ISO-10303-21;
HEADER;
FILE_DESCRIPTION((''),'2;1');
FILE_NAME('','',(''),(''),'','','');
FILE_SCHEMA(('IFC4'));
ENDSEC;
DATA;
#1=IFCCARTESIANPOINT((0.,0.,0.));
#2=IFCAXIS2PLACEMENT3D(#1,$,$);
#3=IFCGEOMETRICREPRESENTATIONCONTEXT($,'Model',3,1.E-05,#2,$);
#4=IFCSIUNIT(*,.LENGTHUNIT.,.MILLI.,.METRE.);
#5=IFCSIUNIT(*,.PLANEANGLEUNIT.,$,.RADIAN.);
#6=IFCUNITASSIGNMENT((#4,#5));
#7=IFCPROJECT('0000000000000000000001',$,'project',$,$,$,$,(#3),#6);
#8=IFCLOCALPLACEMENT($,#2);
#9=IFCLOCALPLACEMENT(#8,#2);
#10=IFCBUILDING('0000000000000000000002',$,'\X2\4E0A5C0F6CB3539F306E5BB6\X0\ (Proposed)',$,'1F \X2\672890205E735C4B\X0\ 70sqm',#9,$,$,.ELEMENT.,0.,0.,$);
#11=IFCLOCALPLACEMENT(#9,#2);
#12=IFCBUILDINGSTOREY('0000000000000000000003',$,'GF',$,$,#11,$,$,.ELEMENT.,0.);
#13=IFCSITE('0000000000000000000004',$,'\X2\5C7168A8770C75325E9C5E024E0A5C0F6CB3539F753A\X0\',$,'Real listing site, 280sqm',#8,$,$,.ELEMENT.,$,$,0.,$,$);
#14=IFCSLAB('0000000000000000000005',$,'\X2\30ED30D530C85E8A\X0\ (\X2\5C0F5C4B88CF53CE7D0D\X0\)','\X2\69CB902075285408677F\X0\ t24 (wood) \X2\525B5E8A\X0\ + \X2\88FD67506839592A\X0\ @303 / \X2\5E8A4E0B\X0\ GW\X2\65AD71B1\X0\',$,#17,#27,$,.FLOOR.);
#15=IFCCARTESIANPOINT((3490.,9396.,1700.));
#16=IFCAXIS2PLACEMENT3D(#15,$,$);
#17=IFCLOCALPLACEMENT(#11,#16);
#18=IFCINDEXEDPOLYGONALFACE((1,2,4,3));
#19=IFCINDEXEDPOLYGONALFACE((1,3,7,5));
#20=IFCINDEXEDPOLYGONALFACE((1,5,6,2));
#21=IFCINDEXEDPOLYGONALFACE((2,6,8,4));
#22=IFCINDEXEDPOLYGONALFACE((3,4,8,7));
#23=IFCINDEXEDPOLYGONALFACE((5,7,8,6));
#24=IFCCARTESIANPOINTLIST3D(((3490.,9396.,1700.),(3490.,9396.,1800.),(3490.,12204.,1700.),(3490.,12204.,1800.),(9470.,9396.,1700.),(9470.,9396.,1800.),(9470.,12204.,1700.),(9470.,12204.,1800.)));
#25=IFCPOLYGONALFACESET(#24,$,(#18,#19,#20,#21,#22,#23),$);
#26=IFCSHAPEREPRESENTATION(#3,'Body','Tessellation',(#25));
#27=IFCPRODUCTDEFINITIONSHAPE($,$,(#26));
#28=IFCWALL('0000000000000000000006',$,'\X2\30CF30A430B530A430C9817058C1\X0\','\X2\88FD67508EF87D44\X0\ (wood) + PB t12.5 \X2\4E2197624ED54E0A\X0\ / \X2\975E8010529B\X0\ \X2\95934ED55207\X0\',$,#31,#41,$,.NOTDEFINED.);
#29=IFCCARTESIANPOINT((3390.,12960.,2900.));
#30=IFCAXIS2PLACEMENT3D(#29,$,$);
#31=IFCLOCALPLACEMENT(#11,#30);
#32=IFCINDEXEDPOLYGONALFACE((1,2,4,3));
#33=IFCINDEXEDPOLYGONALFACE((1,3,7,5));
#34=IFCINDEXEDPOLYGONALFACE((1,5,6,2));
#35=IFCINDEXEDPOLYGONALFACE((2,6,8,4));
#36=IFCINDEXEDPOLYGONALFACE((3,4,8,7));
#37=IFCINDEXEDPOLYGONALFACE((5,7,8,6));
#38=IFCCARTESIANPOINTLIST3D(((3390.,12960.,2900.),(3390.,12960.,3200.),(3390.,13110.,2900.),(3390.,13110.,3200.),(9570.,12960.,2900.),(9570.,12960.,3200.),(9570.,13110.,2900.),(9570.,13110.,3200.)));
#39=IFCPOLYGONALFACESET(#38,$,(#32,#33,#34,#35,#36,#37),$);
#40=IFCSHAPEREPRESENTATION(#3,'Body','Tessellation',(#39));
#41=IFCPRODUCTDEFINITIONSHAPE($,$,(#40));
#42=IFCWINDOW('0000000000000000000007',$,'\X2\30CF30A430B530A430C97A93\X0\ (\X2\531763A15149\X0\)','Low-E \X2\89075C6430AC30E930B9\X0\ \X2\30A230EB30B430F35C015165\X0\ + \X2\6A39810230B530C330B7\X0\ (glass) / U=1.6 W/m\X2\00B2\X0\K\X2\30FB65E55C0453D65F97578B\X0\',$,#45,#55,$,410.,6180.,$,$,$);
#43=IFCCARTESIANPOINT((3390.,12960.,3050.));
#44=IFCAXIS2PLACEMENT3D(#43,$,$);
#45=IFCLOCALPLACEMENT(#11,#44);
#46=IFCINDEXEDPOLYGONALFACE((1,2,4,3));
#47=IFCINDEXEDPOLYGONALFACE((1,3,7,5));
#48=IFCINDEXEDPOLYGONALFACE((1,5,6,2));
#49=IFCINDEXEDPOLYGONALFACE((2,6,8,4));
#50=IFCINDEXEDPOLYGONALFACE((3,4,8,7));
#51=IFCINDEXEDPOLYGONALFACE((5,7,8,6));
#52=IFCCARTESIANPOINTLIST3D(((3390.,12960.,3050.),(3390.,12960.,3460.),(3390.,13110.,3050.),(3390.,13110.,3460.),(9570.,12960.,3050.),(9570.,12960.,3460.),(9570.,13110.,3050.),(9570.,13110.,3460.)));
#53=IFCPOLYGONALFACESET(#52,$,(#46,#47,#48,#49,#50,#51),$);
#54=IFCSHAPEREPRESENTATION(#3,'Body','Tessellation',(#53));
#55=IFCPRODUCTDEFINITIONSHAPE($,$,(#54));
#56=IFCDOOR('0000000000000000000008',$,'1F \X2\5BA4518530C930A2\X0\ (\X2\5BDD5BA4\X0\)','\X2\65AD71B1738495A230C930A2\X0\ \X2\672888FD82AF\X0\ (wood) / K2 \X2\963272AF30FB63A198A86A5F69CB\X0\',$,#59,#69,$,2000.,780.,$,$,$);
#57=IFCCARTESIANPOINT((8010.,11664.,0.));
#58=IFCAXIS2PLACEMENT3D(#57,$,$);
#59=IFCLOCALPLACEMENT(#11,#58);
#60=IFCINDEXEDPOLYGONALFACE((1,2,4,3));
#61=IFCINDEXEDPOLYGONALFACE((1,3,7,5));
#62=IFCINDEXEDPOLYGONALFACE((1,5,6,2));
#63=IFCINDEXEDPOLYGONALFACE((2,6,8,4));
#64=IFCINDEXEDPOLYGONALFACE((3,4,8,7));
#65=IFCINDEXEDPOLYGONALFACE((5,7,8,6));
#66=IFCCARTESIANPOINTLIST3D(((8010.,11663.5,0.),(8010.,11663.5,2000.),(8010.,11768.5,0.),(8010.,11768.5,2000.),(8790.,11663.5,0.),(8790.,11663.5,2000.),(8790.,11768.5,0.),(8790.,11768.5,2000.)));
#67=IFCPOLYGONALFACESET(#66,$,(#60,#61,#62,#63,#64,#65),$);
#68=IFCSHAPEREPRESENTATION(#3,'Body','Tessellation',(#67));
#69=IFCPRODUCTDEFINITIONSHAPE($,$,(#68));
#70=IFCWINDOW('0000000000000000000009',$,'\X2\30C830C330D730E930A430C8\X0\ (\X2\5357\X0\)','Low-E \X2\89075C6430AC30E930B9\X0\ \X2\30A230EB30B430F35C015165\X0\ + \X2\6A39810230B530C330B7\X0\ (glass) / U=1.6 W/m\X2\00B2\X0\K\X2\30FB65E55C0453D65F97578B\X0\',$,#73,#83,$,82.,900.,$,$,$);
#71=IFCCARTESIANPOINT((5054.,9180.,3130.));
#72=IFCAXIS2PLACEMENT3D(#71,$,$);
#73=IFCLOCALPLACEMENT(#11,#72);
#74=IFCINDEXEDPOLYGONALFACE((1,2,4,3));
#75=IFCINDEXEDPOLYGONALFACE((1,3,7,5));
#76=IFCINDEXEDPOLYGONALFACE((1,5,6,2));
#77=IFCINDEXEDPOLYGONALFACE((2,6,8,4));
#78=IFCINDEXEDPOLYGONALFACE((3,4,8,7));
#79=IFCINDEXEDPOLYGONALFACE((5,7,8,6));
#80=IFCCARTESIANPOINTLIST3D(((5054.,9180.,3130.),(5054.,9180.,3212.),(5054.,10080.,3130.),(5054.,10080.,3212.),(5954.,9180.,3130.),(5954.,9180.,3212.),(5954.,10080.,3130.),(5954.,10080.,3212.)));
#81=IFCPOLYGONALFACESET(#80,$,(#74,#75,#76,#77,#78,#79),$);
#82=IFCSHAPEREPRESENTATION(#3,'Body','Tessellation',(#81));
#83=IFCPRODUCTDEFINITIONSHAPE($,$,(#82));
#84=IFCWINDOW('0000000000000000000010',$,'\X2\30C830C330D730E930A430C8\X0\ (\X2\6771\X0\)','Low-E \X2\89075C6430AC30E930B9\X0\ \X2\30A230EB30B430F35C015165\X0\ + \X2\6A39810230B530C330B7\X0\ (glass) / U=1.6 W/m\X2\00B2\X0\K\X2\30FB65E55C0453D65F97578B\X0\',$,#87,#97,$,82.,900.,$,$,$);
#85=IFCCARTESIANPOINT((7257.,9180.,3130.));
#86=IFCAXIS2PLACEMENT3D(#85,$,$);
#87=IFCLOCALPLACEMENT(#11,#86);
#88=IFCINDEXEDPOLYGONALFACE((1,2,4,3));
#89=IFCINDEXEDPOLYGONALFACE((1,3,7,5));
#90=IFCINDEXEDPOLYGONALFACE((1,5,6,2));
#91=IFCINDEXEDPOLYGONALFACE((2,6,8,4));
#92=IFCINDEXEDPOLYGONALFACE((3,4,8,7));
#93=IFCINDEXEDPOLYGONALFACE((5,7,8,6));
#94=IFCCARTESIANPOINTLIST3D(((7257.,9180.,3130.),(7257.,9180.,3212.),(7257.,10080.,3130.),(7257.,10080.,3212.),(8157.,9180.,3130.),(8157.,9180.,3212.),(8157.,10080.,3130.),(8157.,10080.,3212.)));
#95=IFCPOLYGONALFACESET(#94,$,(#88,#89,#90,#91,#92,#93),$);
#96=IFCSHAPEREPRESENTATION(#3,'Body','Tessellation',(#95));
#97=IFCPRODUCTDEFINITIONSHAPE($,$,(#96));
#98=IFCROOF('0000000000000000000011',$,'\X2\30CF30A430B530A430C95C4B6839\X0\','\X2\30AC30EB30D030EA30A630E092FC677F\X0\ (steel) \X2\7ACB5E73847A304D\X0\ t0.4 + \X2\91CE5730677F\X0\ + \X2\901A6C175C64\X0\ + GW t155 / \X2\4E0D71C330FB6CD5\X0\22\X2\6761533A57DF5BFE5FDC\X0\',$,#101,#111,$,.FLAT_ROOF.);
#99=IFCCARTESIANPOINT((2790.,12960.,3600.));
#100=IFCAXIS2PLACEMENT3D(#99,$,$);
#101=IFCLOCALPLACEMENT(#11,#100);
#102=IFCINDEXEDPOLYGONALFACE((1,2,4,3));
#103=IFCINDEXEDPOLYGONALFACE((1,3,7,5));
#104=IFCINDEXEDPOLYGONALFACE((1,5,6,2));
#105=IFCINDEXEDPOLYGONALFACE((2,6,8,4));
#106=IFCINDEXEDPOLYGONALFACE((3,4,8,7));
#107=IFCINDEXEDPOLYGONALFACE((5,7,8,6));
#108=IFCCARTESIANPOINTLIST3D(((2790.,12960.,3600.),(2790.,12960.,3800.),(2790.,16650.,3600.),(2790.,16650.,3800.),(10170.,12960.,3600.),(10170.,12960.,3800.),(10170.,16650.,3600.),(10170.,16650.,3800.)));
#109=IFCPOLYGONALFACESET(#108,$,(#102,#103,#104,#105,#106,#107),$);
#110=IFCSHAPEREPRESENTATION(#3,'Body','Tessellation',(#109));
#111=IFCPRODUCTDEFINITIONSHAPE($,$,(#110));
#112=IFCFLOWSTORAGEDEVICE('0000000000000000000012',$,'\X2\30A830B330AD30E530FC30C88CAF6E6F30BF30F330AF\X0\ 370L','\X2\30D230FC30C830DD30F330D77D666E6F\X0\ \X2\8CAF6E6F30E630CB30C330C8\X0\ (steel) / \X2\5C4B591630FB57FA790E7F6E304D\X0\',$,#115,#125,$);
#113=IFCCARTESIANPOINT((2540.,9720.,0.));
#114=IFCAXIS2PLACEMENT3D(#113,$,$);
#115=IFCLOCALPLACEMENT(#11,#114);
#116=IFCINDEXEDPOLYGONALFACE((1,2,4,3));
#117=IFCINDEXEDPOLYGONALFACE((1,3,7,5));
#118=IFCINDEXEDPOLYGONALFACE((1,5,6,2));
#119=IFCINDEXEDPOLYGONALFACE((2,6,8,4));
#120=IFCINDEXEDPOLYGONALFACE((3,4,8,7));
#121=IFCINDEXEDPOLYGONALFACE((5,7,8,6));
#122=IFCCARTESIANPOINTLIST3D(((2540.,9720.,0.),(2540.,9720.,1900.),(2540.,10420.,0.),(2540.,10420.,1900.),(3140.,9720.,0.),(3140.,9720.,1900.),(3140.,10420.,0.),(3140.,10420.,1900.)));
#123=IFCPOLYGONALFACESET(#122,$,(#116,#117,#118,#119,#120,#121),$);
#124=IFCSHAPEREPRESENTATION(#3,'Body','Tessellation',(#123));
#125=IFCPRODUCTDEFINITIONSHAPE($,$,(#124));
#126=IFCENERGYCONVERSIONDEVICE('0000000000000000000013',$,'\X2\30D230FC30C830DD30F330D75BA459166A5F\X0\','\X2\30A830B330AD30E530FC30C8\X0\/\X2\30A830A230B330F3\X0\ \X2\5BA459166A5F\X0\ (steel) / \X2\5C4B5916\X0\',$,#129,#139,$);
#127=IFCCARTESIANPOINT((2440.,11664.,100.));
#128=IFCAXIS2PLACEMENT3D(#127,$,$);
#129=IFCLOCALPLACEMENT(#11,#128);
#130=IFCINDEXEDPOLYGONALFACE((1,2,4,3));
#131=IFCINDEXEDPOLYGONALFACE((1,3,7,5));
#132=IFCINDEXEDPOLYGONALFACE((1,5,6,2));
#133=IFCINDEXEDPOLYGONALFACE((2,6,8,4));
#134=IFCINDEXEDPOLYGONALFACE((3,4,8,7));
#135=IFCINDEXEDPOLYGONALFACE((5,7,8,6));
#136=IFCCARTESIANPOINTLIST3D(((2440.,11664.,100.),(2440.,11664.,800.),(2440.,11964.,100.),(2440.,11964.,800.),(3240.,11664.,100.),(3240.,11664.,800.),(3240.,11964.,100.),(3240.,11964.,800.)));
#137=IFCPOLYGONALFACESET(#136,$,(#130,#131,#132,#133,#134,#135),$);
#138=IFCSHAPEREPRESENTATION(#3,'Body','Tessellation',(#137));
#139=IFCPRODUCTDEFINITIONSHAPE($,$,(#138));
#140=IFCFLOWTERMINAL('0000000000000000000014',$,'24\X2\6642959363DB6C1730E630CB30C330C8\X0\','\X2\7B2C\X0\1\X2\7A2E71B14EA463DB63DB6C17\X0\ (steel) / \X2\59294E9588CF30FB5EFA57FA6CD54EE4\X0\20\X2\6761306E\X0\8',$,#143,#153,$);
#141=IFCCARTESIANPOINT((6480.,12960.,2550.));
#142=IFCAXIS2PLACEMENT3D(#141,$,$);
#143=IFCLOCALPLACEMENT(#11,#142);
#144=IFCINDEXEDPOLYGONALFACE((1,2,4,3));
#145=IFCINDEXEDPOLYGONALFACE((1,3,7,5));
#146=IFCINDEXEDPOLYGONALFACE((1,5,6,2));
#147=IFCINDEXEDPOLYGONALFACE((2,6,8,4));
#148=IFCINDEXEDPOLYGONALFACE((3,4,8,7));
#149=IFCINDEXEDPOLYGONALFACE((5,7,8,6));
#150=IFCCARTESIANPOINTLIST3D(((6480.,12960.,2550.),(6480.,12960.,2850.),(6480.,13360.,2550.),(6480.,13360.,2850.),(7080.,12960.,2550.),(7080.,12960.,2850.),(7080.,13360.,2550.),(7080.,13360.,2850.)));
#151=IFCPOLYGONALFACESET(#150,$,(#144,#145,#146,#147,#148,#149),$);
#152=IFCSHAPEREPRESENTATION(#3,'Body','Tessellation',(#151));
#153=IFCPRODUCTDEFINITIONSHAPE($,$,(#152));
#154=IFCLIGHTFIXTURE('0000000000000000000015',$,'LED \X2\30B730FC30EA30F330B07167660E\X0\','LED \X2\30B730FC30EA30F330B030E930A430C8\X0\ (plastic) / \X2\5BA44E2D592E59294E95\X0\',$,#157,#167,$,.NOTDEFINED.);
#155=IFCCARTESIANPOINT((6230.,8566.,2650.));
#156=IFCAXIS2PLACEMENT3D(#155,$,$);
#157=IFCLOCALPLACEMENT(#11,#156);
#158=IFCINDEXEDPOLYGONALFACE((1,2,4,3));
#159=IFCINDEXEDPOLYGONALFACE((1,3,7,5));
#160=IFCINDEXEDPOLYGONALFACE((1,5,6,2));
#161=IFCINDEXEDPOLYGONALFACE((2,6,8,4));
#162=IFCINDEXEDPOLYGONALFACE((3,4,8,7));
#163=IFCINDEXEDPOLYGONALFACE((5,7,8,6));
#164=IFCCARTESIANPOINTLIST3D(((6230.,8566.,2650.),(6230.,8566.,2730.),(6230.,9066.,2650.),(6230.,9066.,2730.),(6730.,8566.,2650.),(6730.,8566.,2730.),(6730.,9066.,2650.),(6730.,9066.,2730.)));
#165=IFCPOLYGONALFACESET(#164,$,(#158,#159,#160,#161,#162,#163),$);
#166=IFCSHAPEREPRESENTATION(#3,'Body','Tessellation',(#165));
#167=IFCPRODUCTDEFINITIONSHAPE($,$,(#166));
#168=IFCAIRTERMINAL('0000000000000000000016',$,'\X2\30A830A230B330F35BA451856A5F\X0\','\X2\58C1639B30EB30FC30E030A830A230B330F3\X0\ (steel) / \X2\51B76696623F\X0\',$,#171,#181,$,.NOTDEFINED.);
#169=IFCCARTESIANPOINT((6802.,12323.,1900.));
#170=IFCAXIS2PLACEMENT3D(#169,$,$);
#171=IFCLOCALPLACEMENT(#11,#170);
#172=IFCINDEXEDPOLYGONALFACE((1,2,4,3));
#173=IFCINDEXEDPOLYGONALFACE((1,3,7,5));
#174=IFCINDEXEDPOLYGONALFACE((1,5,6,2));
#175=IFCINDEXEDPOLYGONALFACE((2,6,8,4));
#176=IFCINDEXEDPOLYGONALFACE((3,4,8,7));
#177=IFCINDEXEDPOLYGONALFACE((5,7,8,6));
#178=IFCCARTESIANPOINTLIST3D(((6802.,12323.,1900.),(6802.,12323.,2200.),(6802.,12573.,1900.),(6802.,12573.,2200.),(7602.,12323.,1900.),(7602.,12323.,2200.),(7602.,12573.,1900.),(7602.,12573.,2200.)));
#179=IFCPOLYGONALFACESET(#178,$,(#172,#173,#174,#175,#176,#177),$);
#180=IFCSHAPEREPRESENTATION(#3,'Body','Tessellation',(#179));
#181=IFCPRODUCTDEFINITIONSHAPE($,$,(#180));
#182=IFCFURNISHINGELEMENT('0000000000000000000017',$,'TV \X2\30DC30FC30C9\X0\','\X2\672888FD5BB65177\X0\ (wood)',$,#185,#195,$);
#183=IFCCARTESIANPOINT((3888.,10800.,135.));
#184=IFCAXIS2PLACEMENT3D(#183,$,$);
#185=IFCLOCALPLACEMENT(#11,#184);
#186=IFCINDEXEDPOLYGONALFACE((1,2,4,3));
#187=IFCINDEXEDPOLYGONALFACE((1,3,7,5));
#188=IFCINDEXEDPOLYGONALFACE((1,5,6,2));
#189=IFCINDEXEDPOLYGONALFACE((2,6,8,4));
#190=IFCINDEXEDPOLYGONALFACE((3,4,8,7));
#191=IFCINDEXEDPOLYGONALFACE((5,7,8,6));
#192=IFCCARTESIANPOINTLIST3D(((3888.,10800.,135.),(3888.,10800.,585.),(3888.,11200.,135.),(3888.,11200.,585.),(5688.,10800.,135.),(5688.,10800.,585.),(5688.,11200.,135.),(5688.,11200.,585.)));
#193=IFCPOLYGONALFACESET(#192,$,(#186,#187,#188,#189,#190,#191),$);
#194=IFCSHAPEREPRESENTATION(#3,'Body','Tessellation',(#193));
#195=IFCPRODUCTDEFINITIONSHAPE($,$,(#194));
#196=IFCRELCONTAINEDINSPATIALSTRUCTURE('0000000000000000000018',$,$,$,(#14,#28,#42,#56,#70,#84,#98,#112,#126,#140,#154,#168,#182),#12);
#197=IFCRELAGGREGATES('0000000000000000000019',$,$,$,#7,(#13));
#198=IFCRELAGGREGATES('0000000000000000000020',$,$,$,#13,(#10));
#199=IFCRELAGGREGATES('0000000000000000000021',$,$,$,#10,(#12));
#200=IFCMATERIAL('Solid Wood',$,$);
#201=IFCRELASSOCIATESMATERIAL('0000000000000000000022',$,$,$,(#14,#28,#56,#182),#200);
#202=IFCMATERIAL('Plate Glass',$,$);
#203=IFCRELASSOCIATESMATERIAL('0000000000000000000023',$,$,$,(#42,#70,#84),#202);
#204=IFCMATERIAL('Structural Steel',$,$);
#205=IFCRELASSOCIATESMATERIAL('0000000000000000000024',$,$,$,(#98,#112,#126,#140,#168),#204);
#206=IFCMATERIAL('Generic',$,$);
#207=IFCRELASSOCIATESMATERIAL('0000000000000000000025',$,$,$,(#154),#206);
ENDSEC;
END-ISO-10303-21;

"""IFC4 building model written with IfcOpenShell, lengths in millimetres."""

from ifc_helpers import new_model, si_unit, frame, frame_2d, origin, place, context, project, spatial, rectangle, extrude, material, element, fill, save


model = new_model("IFC4")

# Units and contexts
model_context = context("Model", 3, precision=1e-05, world=origin())
ifc_project = project(units=[si_unit("LENGTHUNIT", "METRE", prefix="MILLI"), si_unit("PLANEANGLEUNIT", "RADIAN")], contexts=[model_context])

# Site, building, storey
site_placement = place(None, origin())
site = spatial("IfcSite", under=ifc_project, at=site_placement, Name="山梨県甲府市上小河原町", ObjectType="Real listing site, 280sqm", CompositionType="ELEMENT", RefElevation=0.0)
building_placement = place(site_placement, origin())
building = spatial("IfcBuilding", under=site, at=building_placement, Name="上小河原の家 (Proposed)", ObjectType="1F 木造平屋 70sqm", CompositionType="ELEMENT", ElevationOfRefHeight=0.0, ElevationOfTerrain=0.0)
storey_placement = place(building_placement, origin())
storey = spatial("IfcBuildingStorey", under=building, at=storey_placement, Name="GF", CompositionType="ELEMENT", Elevation=0.0)

# Shared definitions
ifc_material_1 = material(Name="Solid Wood")

# Slab
slab_placement = place(storey_placement, frame((3490.0, 9396.0, 1700.0)))
element("IfcSlab", 1, at=slab_placement, inside=storey, material=ifc_material_1, Name="ロフト床 (小屋裏収納)", Description="構造用合板 t24 (wood) 剛床 + 製材根太 @303 / 床下 GW断熱", PredefinedType="FLOOR", context=model_context, shape_type="SweptSolid", body=[
    extrude(rectangle(XDim=5980.0, YDim=2808.0, at=frame_2d((2990.0, 1404.0))), frame((3490.0, 9396.0, 1700.0)), (0.0, 0.0, 1.0), 100.0),
])

# Wall, opening, window
wall_1_placement = place(storey_placement, frame((3390.0, 12960.0, 2900.0)))
wall_1 = element("IfcWall", 2, at=wall_1_placement, inside=storey, material=ifc_material_1, Name="ハイサイド腰壁", Description="製材軸組 (wood) + PB t12.5 両面仕上 / 非耐力 間仕切", PredefinedType="NOTDEFINED", context=model_context, shape_type="SweptSolid", body=[
    extrude(rectangle(XDim=6180.0, YDim=150.0, at=frame_2d((3090.0, 75.0))), frame((3390.0, 12960.0, 2900.0)), (0.0, 0.0, 1.0), 700.0),
])
opening_1_placement = place(storey_placement, frame((3390.0, 12960.0, 3050.0)))
opening_1 = element("IfcOpeningElement", 3, at=opening_1_placement, cuts=wall_1, PredefinedType="NOTDEFINED", context=model_context, shape_type="SweptSolid", body=[
    extrude(rectangle(XDim=6180.0, YDim=150.0, at=frame_2d((3090.0, 75.0))), frame((3390.0, 12960.0, 3050.0)), (0.0, 0.0, 1.0), 410.0),
])
ifc_material_2 = material(Name="Plate Glass")
window_1_placement = place(storey_placement, frame((3390.0, 12960.0, 3050.0)))
window_1 = element("IfcWindow", 4, at=window_1_placement, inside=storey, material=ifc_material_2, Name="ハイサイド窓 (北採光)", Description="Low-E 複層ガラス アルゴン封入 + 樹脂サッシ (glass) / U=1.6 W/m²K・日射取得型", OverallHeight=410.0, OverallWidth=6180.0, context=model_context, shape_type="SweptSolid", body=[
    extrude(rectangle(XDim=6180.0, YDim=150.0, at=frame_2d((3090.0, 75.0))), frame((3390.0, 12960.0, 3050.0)), (0.0, 0.0, 1.0), 410.0),
])
fill(opening_1, window_1)

# Door
door_1_placement = place(storey_placement, frame((8010.0, 11664.0, 0.0)))
element("IfcDoor", 5, at=door_1_placement, inside=storey, material=ifc_material_1, Name="1F 室内ドア (寝室)", Description="断熱玄関ドア 木製芯 (wood) / K2 防犯・採風機構", OverallHeight=2000.0, OverallWidth=780.0, context=model_context, shape_type="SweptSolid", body=[
    extrude(rectangle(XDim=780.0, YDim=105.0, at=frame_2d((390.0, 52.0))), frame((8010.0, 11664.0, 0.0)), (0.0, 0.0, 1.0), 2000.0),
])

# Windows
window_2_placement = place(storey_placement, frame((5054.0, 9180.0, 3130.0)))
element("IfcWindow", 6, at=window_2_placement, inside=storey, material=ifc_material_2, Name="トップライト (南)", Description="Low-E 複層ガラス アルゴン封入 + 樹脂サッシ (glass) / U=1.6 W/m²K・日射取得型", OverallHeight=82.0, OverallWidth=900.0, context=model_context, shape_type="SweptSolid", body=[
    extrude(rectangle(XDim=900.0, YDim=900.0, at=frame_2d((450.0, 450.0))), frame((5054.0, 9180.0, 3130.0)), (0.0, 0.0, 1.0), 82.0),
])
window_3_placement = place(storey_placement, frame((7257.0, 9180.0, 3130.0)))
element("IfcWindow", 7, at=window_3_placement, inside=storey, material=ifc_material_2, Name="トップライト (東)", Description="Low-E 複層ガラス アルゴン封入 + 樹脂サッシ (glass) / U=1.6 W/m²K・日射取得型", OverallHeight=82.0, OverallWidth=900.0, context=model_context, shape_type="SweptSolid", body=[
    extrude(rectangle(XDim=900.0, YDim=900.0, at=frame_2d((450.0, 450.0))), frame((7257.0, 9180.0, 3130.0)), (0.0, 0.0, 1.0), 82.0),
])

# Roof
ifc_material_3 = material(Name="Structural Steel")
roof_placement = place(storey_placement, frame((2790.0, 12960.0, 3600.0)))
element("IfcRoof", 8, at=roof_placement, inside=storey, material=ifc_material_3, Name="ハイサイド屋根", Description="ガルバリウム鋼板 (steel) 立平葺き t0.4 + 野地板 + 通気層 + GW t155 / 不燃・法22条区域対応", PredefinedType="FLAT_ROOF", context=model_context, shape_type="SweptSolid", body=[
    extrude(rectangle(XDim=7380.0, YDim=3690.0, at=frame_2d((3690.0, 1845.0))), frame((2790.0, 12960.0, 3600.0)), (0.0, 0.0, 1.0), 200.0),
])

# Flow storage device
flow_storage_device_placement = place(storey_placement, frame((2540.0, 9720.0, 0.0)))
element("IfcFlowStorageDevice", 9, at=flow_storage_device_placement, inside=storey, material=ifc_material_3, Name="エコキュート貯湯タンク 370L", Description="ヒートポンプ給湯 貯湯ユニット (steel) / 屋外・基礎置き", context=model_context, shape_type="SweptSolid", body=[
    extrude(rectangle(XDim=600.0, YDim=700.0, at=frame_2d((300.0, 350.0))), frame((2540.0, 9720.0, 0.0)), (0.0, 0.0, 1.0), 1900.0),
])

# Energy conversion device
energy_conversion_device_placement = place(storey_placement, frame((2440.0, 11664.0, 100.0)))
element("IfcEnergyConversionDevice", 10, at=energy_conversion_device_placement, inside=storey, material=ifc_material_3, Name="ヒートポンプ室外機", Description="エコキュート/エアコン 室外機 (steel) / 屋外", context=model_context, shape_type="SweptSolid", body=[
    extrude(rectangle(XDim=800.0, YDim=300.0, at=frame_2d((400.0, 150.0))), frame((2440.0, 11664.0, 100.0)), (0.0, 0.0, 1.0), 700.0),
])

# Flow terminal
flow_terminal_placement = place(storey_placement, frame((6480.0, 12960.0, 2550.0)))
element("IfcFlowTerminal", 11, at=flow_terminal_placement, inside=storey, material=ifc_material_3, Name="24時間換気ユニット", Description="第1種熱交換換気 (steel) / 天井裏・建基法令20条の8", context=model_context, shape_type="SweptSolid", body=[
    extrude(rectangle(XDim=600.0, YDim=400.0, at=frame_2d((300.0, 200.0))), frame((6480.0, 12960.0, 2550.0)), (0.0, 0.0, 1.0), 300.0),
])

# Light fixture
ifc_material_4 = material(Name="Generic")
light_fixture_placement = place(storey_placement, frame((6230.0, 8566.0, 2650.0)))
element("IfcLightFixture", 12, at=light_fixture_placement, inside=storey, material=ifc_material_4, Name="LED シーリング照明", Description="LED シーリングライト (plastic) / 室中央天井", PredefinedType="NOTDEFINED", context=model_context, shape_type="SweptSolid", body=[
    extrude(rectangle(XDim=500.0, YDim=500.0, at=frame_2d((250.0, 250.0))), frame((6230.0, 8566.0, 2650.0)), (0.0, 0.0, 1.0), 80.0),
])

# Air terminal
air_terminal_placement = place(storey_placement, frame((6802.0, 12323.0, 1900.0)))
element("IfcAirTerminal", 13, at=air_terminal_placement, inside=storey, material=ifc_material_3, Name="エアコン室内機", Description="壁掛ルームエアコン (steel) / 冷暖房", PredefinedType="NOTDEFINED", context=model_context, shape_type="SweptSolid", body=[
    extrude(rectangle(XDim=800.0, YDim=250.0, at=frame_2d((400.0, 125.0))), frame((6802.0, 12323.0, 1900.0)), (0.0, 0.0, 1.0), 300.0),
])

# Furnishing element
furnishing_placement = place(storey_placement, frame((3888.0, 10800.0, 135.0)))
element("IfcFurnishingElement", 14, at=furnishing_placement, inside=storey, material=ifc_material_1, Name="TV ボード", Description="木製家具 (wood)", context=model_context, shape_type="SweptSolid", body=[
    extrude(rectangle(XDim=1800.0, YDim=400.0, at=frame_2d((900.0, 200.0))), frame((3888.0, 10800.0, 135.0)), (0.0, 0.0, 1.0), 450.0),
])

save(model, "model.ifc")
